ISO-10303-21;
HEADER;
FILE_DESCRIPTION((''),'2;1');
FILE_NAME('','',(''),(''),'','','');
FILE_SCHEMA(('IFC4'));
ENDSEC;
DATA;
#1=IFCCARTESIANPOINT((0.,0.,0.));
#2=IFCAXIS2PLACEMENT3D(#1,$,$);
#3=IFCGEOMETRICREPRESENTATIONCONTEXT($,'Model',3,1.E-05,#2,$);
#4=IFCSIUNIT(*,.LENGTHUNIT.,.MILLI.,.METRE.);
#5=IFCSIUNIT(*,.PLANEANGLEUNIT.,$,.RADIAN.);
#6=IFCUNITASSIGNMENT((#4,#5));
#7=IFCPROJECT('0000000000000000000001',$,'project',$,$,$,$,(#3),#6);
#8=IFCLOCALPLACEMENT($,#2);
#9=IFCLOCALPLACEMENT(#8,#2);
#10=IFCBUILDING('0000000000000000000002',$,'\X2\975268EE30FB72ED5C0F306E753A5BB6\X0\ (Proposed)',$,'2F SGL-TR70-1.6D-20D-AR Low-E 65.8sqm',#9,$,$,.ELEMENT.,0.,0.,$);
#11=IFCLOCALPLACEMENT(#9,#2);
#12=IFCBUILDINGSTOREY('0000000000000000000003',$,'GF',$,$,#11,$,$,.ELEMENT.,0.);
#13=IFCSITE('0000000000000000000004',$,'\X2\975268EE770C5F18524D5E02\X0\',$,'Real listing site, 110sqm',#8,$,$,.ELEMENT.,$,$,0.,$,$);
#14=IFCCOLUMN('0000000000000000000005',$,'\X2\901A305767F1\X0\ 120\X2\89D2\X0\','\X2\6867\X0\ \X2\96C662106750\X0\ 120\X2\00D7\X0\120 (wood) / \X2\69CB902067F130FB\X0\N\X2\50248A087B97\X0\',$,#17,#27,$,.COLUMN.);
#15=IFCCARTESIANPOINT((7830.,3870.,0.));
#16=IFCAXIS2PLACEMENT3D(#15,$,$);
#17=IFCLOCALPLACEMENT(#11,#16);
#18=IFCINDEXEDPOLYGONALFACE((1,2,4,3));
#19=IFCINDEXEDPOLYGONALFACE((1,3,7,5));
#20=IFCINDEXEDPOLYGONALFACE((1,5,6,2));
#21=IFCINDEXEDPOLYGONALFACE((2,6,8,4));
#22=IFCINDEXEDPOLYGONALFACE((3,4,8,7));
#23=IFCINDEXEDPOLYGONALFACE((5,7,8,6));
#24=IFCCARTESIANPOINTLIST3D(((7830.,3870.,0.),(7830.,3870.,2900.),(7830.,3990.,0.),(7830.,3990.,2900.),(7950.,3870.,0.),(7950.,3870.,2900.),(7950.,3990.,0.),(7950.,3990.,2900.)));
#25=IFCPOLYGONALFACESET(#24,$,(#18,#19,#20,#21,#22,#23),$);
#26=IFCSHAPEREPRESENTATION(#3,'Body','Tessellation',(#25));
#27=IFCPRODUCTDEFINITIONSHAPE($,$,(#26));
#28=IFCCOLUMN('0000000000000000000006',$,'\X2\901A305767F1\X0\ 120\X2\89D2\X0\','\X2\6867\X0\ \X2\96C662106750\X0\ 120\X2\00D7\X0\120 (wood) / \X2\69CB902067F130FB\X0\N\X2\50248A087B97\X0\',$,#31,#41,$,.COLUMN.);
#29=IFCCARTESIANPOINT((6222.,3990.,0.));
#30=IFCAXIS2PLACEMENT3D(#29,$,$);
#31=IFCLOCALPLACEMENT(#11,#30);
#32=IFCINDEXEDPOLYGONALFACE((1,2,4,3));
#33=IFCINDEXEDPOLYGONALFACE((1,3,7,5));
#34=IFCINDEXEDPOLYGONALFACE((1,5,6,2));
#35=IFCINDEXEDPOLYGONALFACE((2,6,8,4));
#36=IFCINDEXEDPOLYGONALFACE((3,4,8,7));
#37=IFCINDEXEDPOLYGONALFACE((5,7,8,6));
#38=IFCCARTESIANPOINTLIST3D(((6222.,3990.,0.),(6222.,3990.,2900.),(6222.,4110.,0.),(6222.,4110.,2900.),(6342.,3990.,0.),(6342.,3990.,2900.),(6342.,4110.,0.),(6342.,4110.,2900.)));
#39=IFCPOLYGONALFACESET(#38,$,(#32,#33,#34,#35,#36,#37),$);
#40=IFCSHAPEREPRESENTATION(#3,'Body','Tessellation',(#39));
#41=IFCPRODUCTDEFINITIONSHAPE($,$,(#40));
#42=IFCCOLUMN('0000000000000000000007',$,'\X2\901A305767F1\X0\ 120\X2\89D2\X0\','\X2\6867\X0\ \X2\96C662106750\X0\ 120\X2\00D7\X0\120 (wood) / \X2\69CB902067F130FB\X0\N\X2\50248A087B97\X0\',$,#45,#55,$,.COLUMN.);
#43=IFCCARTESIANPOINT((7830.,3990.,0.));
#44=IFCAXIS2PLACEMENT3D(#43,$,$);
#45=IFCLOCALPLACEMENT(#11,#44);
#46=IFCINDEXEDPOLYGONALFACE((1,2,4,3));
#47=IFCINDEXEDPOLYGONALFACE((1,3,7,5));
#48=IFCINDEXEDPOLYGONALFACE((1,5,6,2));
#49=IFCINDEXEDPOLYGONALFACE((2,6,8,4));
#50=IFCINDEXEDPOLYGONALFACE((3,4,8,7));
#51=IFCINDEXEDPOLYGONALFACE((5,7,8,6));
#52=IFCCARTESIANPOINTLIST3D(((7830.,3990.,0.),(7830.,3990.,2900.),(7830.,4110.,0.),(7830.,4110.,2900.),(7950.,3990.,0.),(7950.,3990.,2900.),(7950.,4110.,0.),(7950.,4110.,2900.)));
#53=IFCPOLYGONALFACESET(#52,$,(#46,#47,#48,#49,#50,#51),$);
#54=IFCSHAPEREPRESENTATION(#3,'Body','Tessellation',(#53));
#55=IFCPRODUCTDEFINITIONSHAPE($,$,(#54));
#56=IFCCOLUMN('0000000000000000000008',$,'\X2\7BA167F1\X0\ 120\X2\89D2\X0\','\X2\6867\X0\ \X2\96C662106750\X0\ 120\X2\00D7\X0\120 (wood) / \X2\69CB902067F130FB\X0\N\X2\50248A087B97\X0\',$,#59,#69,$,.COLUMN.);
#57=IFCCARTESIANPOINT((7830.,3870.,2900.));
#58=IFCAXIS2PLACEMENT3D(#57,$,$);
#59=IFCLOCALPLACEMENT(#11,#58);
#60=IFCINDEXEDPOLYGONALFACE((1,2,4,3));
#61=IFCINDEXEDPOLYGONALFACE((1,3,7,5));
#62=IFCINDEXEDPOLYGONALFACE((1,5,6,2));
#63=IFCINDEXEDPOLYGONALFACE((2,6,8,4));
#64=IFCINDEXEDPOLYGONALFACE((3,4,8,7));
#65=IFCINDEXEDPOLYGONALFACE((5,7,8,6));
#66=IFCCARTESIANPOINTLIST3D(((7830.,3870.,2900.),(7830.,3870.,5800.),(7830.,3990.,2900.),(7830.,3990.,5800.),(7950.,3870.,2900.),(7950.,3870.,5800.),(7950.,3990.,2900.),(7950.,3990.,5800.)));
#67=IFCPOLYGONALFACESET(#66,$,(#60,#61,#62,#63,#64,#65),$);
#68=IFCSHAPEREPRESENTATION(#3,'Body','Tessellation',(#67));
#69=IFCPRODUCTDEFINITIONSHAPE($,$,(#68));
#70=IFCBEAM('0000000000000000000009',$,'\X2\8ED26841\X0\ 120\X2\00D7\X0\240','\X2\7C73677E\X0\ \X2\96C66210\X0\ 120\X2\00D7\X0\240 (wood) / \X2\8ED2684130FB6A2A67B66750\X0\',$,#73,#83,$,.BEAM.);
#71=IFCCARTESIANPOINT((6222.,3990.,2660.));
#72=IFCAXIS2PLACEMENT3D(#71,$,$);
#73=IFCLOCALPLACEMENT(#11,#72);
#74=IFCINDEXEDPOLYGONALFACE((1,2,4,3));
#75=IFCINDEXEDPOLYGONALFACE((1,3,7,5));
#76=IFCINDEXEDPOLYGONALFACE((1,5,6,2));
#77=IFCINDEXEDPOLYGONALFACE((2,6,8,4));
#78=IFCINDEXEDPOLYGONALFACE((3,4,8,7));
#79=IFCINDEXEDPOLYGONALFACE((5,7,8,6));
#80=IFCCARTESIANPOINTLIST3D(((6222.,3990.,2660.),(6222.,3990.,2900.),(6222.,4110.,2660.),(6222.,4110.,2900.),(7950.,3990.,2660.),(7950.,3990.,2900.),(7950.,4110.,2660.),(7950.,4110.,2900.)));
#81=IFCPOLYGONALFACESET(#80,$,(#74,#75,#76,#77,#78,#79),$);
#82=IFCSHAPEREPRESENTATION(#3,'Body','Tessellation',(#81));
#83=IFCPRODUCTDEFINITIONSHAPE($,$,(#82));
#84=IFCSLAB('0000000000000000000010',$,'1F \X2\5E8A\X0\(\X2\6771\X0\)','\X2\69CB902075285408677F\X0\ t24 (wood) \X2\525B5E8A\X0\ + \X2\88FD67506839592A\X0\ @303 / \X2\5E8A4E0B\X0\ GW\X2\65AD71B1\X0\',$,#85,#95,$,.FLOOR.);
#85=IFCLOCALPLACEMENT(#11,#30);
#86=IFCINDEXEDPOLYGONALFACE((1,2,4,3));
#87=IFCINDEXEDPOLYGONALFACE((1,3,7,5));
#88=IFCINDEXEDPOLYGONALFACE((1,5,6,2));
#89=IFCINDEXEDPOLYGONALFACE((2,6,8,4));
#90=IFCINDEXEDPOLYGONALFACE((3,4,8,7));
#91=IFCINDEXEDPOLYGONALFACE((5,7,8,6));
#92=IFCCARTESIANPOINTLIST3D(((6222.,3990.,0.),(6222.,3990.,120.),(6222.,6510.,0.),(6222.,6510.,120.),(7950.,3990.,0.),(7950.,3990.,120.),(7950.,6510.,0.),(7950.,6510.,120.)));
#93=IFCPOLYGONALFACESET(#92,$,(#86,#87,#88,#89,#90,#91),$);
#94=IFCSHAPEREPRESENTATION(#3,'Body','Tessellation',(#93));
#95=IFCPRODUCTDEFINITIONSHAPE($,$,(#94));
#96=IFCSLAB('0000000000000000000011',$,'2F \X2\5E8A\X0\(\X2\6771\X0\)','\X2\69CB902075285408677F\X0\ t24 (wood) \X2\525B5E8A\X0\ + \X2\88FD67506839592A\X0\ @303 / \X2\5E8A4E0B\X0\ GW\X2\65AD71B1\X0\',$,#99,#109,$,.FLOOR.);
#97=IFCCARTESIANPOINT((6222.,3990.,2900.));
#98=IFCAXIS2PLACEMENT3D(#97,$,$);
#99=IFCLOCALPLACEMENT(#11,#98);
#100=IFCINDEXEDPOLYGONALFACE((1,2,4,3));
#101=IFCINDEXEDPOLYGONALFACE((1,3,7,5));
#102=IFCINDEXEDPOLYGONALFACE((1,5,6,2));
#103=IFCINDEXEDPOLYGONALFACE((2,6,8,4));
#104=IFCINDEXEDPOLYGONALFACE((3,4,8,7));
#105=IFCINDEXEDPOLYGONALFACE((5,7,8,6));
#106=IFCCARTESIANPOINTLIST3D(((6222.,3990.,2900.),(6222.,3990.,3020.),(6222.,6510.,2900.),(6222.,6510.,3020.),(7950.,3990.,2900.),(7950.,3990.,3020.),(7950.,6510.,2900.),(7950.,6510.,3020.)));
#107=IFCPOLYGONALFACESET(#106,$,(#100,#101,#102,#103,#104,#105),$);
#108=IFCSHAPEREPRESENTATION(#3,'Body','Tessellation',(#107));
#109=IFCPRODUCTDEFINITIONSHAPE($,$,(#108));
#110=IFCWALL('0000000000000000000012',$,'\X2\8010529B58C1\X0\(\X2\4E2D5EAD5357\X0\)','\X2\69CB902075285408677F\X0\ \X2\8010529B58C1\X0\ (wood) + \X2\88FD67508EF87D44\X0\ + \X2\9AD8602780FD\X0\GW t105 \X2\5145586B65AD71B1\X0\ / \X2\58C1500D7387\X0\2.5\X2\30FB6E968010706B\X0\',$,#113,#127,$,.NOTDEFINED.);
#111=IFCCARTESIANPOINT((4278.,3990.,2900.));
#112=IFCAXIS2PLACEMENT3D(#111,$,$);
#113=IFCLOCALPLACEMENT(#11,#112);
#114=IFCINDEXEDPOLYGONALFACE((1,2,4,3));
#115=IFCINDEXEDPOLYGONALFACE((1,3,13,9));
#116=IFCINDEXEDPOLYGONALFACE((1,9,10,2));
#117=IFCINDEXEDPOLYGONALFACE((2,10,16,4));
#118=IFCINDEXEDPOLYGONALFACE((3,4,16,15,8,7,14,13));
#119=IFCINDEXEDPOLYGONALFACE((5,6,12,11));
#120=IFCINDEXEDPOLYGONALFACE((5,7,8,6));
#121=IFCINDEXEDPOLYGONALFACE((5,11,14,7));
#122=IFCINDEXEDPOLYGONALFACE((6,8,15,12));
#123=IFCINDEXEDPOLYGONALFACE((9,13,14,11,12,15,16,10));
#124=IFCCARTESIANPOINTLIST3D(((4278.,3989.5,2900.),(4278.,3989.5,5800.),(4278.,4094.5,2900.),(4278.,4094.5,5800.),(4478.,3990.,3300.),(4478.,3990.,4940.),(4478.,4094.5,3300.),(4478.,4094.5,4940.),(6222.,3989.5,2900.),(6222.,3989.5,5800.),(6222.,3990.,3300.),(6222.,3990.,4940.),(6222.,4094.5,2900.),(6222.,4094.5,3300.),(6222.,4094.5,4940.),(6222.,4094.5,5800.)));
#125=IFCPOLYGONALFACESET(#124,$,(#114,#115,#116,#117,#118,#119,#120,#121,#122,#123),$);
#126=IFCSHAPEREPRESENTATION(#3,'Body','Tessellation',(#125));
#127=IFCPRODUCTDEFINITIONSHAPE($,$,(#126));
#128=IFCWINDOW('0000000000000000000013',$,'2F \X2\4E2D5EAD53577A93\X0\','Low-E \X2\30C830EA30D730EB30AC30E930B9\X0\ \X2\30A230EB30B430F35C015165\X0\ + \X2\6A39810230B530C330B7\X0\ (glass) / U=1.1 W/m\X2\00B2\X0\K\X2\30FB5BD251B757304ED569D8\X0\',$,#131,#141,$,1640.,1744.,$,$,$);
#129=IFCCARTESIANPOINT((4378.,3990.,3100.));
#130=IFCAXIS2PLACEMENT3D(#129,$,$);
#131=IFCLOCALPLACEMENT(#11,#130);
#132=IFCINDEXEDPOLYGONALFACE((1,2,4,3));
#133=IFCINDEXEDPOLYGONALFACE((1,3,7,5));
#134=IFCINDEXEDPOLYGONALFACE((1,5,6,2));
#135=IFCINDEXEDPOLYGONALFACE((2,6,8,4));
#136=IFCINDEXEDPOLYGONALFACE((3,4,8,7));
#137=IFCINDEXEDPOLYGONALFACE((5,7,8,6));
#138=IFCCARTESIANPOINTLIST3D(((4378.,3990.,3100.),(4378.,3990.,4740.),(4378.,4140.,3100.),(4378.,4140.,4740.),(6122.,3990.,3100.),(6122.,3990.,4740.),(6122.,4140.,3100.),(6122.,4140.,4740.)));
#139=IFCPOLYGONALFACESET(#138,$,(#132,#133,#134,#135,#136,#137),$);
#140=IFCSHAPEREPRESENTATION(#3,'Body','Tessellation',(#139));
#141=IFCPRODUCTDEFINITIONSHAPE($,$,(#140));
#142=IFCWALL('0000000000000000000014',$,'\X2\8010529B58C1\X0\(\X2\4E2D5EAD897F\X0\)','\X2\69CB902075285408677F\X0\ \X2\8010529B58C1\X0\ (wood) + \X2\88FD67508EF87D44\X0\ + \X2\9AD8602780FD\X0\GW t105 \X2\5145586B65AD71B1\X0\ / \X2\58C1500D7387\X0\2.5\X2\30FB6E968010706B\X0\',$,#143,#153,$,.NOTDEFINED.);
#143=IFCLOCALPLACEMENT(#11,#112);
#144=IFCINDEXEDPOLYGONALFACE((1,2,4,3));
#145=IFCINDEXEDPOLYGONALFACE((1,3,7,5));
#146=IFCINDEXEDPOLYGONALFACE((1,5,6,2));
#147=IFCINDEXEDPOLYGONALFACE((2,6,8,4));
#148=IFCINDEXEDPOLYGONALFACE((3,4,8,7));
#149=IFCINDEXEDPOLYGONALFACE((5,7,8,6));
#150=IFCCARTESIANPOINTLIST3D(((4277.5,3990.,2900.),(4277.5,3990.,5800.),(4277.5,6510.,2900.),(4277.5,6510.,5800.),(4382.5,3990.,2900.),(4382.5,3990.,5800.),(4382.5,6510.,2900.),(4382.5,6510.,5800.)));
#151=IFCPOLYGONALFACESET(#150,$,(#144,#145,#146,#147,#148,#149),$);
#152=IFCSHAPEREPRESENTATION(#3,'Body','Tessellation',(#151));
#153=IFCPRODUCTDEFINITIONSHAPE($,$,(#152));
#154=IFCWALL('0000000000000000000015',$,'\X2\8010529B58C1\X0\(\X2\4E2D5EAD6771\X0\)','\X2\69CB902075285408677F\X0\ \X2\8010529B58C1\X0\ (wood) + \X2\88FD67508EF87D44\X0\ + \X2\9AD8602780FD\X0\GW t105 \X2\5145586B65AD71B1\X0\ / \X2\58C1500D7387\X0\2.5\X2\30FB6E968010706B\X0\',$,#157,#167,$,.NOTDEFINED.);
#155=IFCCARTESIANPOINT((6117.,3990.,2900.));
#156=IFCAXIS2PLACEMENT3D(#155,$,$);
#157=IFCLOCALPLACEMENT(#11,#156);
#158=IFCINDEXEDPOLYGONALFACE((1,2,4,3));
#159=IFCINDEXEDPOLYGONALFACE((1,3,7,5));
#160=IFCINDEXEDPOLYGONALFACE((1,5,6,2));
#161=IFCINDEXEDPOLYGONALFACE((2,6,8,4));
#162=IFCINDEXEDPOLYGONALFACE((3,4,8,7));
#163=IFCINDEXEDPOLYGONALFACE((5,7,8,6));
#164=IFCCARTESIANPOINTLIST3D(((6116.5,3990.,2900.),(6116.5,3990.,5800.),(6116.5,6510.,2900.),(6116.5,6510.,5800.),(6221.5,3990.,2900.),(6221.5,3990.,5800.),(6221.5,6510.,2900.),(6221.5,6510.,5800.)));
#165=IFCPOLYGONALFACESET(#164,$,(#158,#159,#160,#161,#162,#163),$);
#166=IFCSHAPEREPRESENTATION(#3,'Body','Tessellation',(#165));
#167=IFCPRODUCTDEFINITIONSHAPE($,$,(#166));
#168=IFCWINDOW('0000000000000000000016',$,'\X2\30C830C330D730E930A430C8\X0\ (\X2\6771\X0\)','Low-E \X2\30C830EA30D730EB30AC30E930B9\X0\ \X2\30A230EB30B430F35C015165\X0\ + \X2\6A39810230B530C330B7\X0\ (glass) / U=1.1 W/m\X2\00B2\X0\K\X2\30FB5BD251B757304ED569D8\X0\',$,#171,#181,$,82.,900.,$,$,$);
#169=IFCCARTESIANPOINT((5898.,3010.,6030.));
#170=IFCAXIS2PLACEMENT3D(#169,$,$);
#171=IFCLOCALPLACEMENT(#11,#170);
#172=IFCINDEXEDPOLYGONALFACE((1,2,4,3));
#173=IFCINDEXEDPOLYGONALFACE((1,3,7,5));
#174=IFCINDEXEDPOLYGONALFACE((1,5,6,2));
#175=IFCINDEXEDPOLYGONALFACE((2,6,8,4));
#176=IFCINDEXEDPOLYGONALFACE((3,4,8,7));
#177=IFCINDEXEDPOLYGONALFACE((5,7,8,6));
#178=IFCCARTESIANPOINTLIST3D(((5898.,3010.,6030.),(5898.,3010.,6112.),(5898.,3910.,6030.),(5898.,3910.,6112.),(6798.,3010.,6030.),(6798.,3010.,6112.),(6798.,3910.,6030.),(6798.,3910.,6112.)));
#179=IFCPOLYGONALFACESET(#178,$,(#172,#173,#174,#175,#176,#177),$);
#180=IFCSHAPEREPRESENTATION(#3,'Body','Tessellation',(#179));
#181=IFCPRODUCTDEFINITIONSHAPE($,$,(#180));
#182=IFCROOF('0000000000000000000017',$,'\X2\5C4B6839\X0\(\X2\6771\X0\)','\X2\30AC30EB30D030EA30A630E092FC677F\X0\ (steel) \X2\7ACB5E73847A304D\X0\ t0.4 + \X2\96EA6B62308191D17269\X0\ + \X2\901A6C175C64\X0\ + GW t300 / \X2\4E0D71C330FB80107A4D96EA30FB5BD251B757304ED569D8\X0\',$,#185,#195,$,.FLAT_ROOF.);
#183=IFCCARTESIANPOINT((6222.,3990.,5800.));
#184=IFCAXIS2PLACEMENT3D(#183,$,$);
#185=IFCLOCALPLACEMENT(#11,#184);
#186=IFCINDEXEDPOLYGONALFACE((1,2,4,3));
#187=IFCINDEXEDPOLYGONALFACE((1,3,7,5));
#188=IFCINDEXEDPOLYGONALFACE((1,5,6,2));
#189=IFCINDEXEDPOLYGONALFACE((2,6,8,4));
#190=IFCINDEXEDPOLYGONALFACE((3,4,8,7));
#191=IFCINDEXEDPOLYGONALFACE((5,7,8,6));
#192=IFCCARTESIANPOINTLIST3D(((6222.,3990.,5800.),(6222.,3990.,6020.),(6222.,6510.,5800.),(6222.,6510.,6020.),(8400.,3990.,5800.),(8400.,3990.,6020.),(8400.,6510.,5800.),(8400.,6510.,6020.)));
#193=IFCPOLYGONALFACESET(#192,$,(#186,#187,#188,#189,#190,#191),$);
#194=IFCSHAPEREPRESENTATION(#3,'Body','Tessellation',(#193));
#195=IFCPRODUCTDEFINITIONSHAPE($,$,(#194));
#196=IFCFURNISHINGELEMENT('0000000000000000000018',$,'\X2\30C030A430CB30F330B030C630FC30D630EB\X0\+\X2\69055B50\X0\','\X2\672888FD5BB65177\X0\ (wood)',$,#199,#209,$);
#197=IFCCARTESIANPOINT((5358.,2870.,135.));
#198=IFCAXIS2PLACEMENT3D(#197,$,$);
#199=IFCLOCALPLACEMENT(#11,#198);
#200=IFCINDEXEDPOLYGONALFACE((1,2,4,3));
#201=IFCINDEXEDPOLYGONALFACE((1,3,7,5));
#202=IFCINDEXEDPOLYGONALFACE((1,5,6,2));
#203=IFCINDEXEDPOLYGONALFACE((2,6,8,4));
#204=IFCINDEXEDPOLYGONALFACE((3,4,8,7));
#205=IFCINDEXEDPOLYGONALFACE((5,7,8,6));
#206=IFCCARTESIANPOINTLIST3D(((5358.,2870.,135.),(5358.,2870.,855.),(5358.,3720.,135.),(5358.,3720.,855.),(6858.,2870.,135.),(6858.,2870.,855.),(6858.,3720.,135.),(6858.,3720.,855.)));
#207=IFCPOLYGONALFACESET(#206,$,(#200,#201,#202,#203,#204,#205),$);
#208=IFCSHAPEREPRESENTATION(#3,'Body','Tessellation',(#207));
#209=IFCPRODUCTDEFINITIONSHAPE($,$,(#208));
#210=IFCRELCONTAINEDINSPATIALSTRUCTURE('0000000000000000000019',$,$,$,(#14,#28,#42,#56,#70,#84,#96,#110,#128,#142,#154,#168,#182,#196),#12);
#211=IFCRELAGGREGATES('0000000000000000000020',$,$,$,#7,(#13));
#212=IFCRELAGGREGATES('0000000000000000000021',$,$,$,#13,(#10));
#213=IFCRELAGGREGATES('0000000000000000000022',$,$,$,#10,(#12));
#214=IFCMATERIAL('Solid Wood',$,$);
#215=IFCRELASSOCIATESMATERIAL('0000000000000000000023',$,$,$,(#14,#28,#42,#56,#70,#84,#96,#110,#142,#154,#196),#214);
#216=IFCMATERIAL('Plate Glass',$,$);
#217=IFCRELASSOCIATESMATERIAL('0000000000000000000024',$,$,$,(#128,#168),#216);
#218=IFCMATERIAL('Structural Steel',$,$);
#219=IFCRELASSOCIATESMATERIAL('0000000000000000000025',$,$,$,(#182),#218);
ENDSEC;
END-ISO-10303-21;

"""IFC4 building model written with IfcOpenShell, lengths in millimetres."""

from ifc_helpers import new_model, si_unit, frame, frame_2d, origin, place, context, project, spatial, rectangle, extrude, material, element, fill, save


model = new_model("IFC4")

# Units and contexts
model_context = context("Model", 3, precision=1e-05, world=origin())
ifc_project = project(units=[si_unit("LENGTHUNIT", "METRE", prefix="MILLI"), si_unit("PLANEANGLEUNIT", "RADIAN")], contexts=[model_context])

# Site, building, storey
site_placement = place(None, origin())
site = spatial("IfcSite", under=ifc_project, at=site_placement, Name="青森県弘前市", ObjectType="Real listing site, 110sqm", CompositionType="ELEMENT", RefElevation=0.0)
building_placement = place(site_placement, origin())
building = spatial("IfcBuilding", under=site, at=building_placement, Name="青森・狭小の町家 (Proposed)", ObjectType="2F SGL-TR70-1.6D-20D-AR Low-E 65.8sqm", CompositionType="ELEMENT", ElevationOfRefHeight=0.0, ElevationOfTerrain=0.0)
storey_placement = place(building_placement, origin())
storey = spatial("IfcBuildingStorey", under=building, at=storey_placement, Name="GF", CompositionType="ELEMENT", Elevation=0.0)

# Columns
ifc_material_1 = material(Name="Solid Wood")
column_1_placement = place(storey_placement, frame((7830.0, 3870.0, 0.0)))
element("IfcColumn", 1, at=column_1_placement, inside=storey, material=ifc_material_1, Name="通し柱 120角", Description="桧 集成材 120×120 (wood) / 構造柱・N値計算", PredefinedType="COLUMN", context=model_context, shape_type="SweptSolid", body=[
    extrude(rectangle(XDim=120.0, YDim=120.0, at=frame_2d((60.0, 60.0))), frame((7830.0, 3870.0, 0.0)), (0.0, 0.0, 1.0), 2900.0),
])
column_2_placement = place(storey_placement, frame((6222.0, 3990.0, 0.0)))
element("IfcColumn", 2, at=column_2_placement, inside=storey, material=ifc_material_1, Name="通し柱 120角", Description="桧 集成材 120×120 (wood) / 構造柱・N値計算", PredefinedType="COLUMN", context=model_context, shape_type="SweptSolid", body=[
    extrude(rectangle(XDim=120.0, YDim=120.0, at=frame_2d((60.0, 60.0))), frame((6222.0, 3990.0, 0.0)), (0.0, 0.0, 1.0), 2900.0),
])
column_3_placement = place(storey_placement, frame((7830.0, 3990.0, 0.0)))
element("IfcColumn", 3, at=column_3_placement, inside=storey, material=ifc_material_1, Name="通し柱 120角", Description="桧 集成材 120×120 (wood) / 構造柱・N値計算", PredefinedType="COLUMN", context=model_context, shape_type="SweptSolid", body=[
    extrude(rectangle(XDim=120.0, YDim=120.0, at=frame_2d((60.0, 60.0))), frame((7830.0, 3990.0, 0.0)), (0.0, 0.0, 1.0), 2900.0),
])
column_4_placement = place(storey_placement, frame((7830.0, 3870.0, 2900.0)))
element("IfcColumn", 4, at=column_4_placement, inside=storey, material=ifc_material_1, Name="管柱 120角", Description="桧 集成材 120×120 (wood) / 構造柱・N値計算", PredefinedType="COLUMN", context=model_context, shape_type="SweptSolid", body=[
    extrude(rectangle(XDim=120.0, YDim=120.0, at=frame_2d((60.0, 60.0))), frame((7830.0, 3870.0, 2900.0)), (0.0, 0.0, 1.0), 2900.0),
])

# Beam
beam_1_placement = place(storey_placement, frame((6222.0, 3990.0, 2660.0)))
element("IfcBeam", 5, at=beam_1_placement, inside=storey, material=ifc_material_1, Name="軒桁 120×240", Description="米松 集成 120×240 (wood) / 軒桁・横架材", PredefinedType="BEAM", context=model_context, shape_type="SweptSolid", body=[
    extrude(rectangle(XDim=1728.0, YDim=120.0, at=frame_2d((864.0, 60.0))), frame((6222.0, 3990.0, 2660.0)), (0.0, 0.0, 1.0), 240.0),
])

# Slabs
slab_1_placement = place(storey_placement, frame((6222.0, 3990.0, 0.0)))
element("IfcSlab", 6, at=slab_1_placement, inside=storey, material=ifc_material_1, Name="1F 床(東)", Description="構造用合板 t24 (wood) 剛床 + 製材根太 @303 / 床下 GW断熱", PredefinedType="FLOOR", context=model_context, shape_type="SweptSolid", body=[
    extrude(rectangle(XDim=1728.0, YDim=2520.0, at=frame_2d((864.0, 1260.0))), frame((6222.0, 3990.0, 0.0)), (0.0, 0.0, 1.0), 120.0),
])
slab_2_placement = place(storey_placement, frame((6222.0, 3990.0, 2900.0)))
element("IfcSlab", 7, at=slab_2_placement, inside=storey, material=ifc_material_1, Name="2F 床(東)", Description="構造用合板 t24 (wood) 剛床 + 製材根太 @303 / 床下 GW断熱", PredefinedType="FLOOR", context=model_context, shape_type="SweptSolid", body=[
    extrude(rectangle(XDim=1728.0, YDim=2520.0, at=frame_2d((864.0, 1260.0))), frame((6222.0, 3990.0, 2900.0)), (0.0, 0.0, 1.0), 120.0),
])

# Wall, opening, window
wall_1_placement = place(storey_placement, frame((4278.0, 3990.0, 2900.0)))
wall_1 = element("IfcWall", 8, at=wall_1_placement, inside=storey, material=ifc_material_1, Name="耐力壁(中庭南)", Description="構造用合板 耐力壁 (wood) + 製材軸組 + 高性能GW t105 充填断熱 / 壁倍率2.5・準耐火", PredefinedType="NOTDEFINED", context=model_context, shape_type="SweptSolid", body=[
    extrude(rectangle(XDim=1944.0, YDim=105.0, at=frame_2d((972.0, 52.0))), frame((4278.0, 3990.0, 2900.0)), (0.0, 0.0, 1.0), 2900.0),
])
opening_placement = place(storey_placement, frame((4378.0, 3990.0, 3100.0)))
opening = element("IfcOpeningElement", 9, at=opening_placement, cuts=wall_1, PredefinedType="NOTDEFINED", context=model_context, shape_type="SweptSolid", body=[
    extrude(rectangle(XDim=1744.0, YDim=150.0, at=frame_2d((872.0, 75.0))), frame((4378.0, 3990.0, 3100.0)), (0.0, 0.0, 1.0), 1640.0),
])
ifc_material_2 = material(Name="Plate Glass")
window_1_placement = place(storey_placement, frame((4378.0, 3990.0, 3100.0)))
window_1 = element("IfcWindow", 10, at=window_1_placement, inside=storey, material=ifc_material_2, Name="2F 中庭南窓", Description="Low-E トリプルガラス アルゴン封入 + 樹脂サッシ (glass) / U=1.1 W/m²K・寒冷地仕様", OverallHeight=1640.0, OverallWidth=1744.0, context=model_context, shape_type="SweptSolid", body=[
    extrude(rectangle(XDim=1744.0, YDim=150.0, at=frame_2d((872.0, 75.0))), frame((4378.0, 3990.0, 3100.0)), (0.0, 0.0, 1.0), 1640.0),
])
fill(opening, window_1)

# Walls
wall_2_placement = place(storey_placement, frame((4278.0, 3990.0, 2900.0)))
element("IfcWall", 11, at=wall_2_placement, inside=storey, material=ifc_material_1, Name="耐力壁(中庭西)", Description="構造用合板 耐力壁 (wood) + 製材軸組 + 高性能GW t105 充填断熱 / 壁倍率2.5・準耐火", PredefinedType="NOTDEFINED", context=model_context, shape_type="SweptSolid", body=[
    extrude(rectangle(XDim=105.0, YDim=2520.0, at=frame_2d((52.0, 1260.0))), frame((4278.0, 3990.0, 2900.0)), (0.0, 0.0, 1.0), 2900.0),
])
wall_3_placement = place(storey_placement, frame((6117.0, 3990.0, 2900.0)))
element("IfcWall", 12, at=wall_3_placement, inside=storey, material=ifc_material_1, Name="耐力壁(中庭東)", Description="構造用合板 耐力壁 (wood) + 製材軸組 + 高性能GW t105 充填断熱 / 壁倍率2.5・準耐火", PredefinedType="NOTDEFINED", context=model_context, shape_type="SweptSolid", body=[
    extrude(rectangle(XDim=105.0, YDim=2520.0, at=frame_2d((52.0, 1260.0))), frame((6117.0, 3990.0, 2900.0)), (0.0, 0.0, 1.0), 2900.0),
])

# Window
window_2_placement = place(storey_placement, frame((5898.0, 3010.0, 6030.0)))
element("IfcWindow", 13, at=window_2_placement, inside=storey, material=ifc_material_2, Name="トップライト (東)", Description="Low-E トリプルガラス アルゴン封入 + 樹脂サッシ (glass) / U=1.1 W/m²K・寒冷地仕様", OverallHeight=82.0, OverallWidth=900.0, context=model_context, shape_type="SweptSolid", body=[
    extrude(rectangle(XDim=900.0, YDim=900.0, at=frame_2d((450.0, 450.0))), frame((5898.0, 3010.0, 6030.0)), (0.0, 0.0, 1.0), 82.0),
])

# Roof
ifc_material_3 = material(Name="Structural Steel")
for number, where, name in (
    (14, (6222.0, 3990.0, 5800.0), "屋根(東)"),
):
    element("IfcRoof", number, at=place(storey_placement, frame(where)), inside=storey, material=ifc_material_3, Name=name, Description="ガルバリウム鋼板 (steel) 立平葺き t0.4 + 雪止め金物 + 通気層 + GW t300 / 不燃・耐積雪・寒冷地仕様", PredefinedType="FLAT_ROOF", context=model_context, shape_type="SweptSolid", body=[
        extrude(rectangle(XDim=2178.0, YDim=2520.0, at=frame_2d((1089.0, 1260.0))), frame((6222.0, 3990.0, 5800.0)), (0.0, 0.0, 1.0), 220.0),
    ])

# Furnishing element
furnishing_1_placement = place(storey_placement, frame((5358.0, 2870.0, 135.0)))
element("IfcFurnishingElement", 15, at=furnishing_1_placement, inside=storey, material=ifc_material_1, Name="ダイニングテーブル+椅子", Description="木製家具 (wood)", context=model_context, shape_type="SweptSolid", body=[
    extrude(rectangle(XDim=1500.0, YDim=850.0, at=frame_2d((750.0, 425.0))), frame((5358.0, 2870.0, 135.0)), (0.0, 0.0, 1.0), 720.0),
])

save(model, "model.ifc")
